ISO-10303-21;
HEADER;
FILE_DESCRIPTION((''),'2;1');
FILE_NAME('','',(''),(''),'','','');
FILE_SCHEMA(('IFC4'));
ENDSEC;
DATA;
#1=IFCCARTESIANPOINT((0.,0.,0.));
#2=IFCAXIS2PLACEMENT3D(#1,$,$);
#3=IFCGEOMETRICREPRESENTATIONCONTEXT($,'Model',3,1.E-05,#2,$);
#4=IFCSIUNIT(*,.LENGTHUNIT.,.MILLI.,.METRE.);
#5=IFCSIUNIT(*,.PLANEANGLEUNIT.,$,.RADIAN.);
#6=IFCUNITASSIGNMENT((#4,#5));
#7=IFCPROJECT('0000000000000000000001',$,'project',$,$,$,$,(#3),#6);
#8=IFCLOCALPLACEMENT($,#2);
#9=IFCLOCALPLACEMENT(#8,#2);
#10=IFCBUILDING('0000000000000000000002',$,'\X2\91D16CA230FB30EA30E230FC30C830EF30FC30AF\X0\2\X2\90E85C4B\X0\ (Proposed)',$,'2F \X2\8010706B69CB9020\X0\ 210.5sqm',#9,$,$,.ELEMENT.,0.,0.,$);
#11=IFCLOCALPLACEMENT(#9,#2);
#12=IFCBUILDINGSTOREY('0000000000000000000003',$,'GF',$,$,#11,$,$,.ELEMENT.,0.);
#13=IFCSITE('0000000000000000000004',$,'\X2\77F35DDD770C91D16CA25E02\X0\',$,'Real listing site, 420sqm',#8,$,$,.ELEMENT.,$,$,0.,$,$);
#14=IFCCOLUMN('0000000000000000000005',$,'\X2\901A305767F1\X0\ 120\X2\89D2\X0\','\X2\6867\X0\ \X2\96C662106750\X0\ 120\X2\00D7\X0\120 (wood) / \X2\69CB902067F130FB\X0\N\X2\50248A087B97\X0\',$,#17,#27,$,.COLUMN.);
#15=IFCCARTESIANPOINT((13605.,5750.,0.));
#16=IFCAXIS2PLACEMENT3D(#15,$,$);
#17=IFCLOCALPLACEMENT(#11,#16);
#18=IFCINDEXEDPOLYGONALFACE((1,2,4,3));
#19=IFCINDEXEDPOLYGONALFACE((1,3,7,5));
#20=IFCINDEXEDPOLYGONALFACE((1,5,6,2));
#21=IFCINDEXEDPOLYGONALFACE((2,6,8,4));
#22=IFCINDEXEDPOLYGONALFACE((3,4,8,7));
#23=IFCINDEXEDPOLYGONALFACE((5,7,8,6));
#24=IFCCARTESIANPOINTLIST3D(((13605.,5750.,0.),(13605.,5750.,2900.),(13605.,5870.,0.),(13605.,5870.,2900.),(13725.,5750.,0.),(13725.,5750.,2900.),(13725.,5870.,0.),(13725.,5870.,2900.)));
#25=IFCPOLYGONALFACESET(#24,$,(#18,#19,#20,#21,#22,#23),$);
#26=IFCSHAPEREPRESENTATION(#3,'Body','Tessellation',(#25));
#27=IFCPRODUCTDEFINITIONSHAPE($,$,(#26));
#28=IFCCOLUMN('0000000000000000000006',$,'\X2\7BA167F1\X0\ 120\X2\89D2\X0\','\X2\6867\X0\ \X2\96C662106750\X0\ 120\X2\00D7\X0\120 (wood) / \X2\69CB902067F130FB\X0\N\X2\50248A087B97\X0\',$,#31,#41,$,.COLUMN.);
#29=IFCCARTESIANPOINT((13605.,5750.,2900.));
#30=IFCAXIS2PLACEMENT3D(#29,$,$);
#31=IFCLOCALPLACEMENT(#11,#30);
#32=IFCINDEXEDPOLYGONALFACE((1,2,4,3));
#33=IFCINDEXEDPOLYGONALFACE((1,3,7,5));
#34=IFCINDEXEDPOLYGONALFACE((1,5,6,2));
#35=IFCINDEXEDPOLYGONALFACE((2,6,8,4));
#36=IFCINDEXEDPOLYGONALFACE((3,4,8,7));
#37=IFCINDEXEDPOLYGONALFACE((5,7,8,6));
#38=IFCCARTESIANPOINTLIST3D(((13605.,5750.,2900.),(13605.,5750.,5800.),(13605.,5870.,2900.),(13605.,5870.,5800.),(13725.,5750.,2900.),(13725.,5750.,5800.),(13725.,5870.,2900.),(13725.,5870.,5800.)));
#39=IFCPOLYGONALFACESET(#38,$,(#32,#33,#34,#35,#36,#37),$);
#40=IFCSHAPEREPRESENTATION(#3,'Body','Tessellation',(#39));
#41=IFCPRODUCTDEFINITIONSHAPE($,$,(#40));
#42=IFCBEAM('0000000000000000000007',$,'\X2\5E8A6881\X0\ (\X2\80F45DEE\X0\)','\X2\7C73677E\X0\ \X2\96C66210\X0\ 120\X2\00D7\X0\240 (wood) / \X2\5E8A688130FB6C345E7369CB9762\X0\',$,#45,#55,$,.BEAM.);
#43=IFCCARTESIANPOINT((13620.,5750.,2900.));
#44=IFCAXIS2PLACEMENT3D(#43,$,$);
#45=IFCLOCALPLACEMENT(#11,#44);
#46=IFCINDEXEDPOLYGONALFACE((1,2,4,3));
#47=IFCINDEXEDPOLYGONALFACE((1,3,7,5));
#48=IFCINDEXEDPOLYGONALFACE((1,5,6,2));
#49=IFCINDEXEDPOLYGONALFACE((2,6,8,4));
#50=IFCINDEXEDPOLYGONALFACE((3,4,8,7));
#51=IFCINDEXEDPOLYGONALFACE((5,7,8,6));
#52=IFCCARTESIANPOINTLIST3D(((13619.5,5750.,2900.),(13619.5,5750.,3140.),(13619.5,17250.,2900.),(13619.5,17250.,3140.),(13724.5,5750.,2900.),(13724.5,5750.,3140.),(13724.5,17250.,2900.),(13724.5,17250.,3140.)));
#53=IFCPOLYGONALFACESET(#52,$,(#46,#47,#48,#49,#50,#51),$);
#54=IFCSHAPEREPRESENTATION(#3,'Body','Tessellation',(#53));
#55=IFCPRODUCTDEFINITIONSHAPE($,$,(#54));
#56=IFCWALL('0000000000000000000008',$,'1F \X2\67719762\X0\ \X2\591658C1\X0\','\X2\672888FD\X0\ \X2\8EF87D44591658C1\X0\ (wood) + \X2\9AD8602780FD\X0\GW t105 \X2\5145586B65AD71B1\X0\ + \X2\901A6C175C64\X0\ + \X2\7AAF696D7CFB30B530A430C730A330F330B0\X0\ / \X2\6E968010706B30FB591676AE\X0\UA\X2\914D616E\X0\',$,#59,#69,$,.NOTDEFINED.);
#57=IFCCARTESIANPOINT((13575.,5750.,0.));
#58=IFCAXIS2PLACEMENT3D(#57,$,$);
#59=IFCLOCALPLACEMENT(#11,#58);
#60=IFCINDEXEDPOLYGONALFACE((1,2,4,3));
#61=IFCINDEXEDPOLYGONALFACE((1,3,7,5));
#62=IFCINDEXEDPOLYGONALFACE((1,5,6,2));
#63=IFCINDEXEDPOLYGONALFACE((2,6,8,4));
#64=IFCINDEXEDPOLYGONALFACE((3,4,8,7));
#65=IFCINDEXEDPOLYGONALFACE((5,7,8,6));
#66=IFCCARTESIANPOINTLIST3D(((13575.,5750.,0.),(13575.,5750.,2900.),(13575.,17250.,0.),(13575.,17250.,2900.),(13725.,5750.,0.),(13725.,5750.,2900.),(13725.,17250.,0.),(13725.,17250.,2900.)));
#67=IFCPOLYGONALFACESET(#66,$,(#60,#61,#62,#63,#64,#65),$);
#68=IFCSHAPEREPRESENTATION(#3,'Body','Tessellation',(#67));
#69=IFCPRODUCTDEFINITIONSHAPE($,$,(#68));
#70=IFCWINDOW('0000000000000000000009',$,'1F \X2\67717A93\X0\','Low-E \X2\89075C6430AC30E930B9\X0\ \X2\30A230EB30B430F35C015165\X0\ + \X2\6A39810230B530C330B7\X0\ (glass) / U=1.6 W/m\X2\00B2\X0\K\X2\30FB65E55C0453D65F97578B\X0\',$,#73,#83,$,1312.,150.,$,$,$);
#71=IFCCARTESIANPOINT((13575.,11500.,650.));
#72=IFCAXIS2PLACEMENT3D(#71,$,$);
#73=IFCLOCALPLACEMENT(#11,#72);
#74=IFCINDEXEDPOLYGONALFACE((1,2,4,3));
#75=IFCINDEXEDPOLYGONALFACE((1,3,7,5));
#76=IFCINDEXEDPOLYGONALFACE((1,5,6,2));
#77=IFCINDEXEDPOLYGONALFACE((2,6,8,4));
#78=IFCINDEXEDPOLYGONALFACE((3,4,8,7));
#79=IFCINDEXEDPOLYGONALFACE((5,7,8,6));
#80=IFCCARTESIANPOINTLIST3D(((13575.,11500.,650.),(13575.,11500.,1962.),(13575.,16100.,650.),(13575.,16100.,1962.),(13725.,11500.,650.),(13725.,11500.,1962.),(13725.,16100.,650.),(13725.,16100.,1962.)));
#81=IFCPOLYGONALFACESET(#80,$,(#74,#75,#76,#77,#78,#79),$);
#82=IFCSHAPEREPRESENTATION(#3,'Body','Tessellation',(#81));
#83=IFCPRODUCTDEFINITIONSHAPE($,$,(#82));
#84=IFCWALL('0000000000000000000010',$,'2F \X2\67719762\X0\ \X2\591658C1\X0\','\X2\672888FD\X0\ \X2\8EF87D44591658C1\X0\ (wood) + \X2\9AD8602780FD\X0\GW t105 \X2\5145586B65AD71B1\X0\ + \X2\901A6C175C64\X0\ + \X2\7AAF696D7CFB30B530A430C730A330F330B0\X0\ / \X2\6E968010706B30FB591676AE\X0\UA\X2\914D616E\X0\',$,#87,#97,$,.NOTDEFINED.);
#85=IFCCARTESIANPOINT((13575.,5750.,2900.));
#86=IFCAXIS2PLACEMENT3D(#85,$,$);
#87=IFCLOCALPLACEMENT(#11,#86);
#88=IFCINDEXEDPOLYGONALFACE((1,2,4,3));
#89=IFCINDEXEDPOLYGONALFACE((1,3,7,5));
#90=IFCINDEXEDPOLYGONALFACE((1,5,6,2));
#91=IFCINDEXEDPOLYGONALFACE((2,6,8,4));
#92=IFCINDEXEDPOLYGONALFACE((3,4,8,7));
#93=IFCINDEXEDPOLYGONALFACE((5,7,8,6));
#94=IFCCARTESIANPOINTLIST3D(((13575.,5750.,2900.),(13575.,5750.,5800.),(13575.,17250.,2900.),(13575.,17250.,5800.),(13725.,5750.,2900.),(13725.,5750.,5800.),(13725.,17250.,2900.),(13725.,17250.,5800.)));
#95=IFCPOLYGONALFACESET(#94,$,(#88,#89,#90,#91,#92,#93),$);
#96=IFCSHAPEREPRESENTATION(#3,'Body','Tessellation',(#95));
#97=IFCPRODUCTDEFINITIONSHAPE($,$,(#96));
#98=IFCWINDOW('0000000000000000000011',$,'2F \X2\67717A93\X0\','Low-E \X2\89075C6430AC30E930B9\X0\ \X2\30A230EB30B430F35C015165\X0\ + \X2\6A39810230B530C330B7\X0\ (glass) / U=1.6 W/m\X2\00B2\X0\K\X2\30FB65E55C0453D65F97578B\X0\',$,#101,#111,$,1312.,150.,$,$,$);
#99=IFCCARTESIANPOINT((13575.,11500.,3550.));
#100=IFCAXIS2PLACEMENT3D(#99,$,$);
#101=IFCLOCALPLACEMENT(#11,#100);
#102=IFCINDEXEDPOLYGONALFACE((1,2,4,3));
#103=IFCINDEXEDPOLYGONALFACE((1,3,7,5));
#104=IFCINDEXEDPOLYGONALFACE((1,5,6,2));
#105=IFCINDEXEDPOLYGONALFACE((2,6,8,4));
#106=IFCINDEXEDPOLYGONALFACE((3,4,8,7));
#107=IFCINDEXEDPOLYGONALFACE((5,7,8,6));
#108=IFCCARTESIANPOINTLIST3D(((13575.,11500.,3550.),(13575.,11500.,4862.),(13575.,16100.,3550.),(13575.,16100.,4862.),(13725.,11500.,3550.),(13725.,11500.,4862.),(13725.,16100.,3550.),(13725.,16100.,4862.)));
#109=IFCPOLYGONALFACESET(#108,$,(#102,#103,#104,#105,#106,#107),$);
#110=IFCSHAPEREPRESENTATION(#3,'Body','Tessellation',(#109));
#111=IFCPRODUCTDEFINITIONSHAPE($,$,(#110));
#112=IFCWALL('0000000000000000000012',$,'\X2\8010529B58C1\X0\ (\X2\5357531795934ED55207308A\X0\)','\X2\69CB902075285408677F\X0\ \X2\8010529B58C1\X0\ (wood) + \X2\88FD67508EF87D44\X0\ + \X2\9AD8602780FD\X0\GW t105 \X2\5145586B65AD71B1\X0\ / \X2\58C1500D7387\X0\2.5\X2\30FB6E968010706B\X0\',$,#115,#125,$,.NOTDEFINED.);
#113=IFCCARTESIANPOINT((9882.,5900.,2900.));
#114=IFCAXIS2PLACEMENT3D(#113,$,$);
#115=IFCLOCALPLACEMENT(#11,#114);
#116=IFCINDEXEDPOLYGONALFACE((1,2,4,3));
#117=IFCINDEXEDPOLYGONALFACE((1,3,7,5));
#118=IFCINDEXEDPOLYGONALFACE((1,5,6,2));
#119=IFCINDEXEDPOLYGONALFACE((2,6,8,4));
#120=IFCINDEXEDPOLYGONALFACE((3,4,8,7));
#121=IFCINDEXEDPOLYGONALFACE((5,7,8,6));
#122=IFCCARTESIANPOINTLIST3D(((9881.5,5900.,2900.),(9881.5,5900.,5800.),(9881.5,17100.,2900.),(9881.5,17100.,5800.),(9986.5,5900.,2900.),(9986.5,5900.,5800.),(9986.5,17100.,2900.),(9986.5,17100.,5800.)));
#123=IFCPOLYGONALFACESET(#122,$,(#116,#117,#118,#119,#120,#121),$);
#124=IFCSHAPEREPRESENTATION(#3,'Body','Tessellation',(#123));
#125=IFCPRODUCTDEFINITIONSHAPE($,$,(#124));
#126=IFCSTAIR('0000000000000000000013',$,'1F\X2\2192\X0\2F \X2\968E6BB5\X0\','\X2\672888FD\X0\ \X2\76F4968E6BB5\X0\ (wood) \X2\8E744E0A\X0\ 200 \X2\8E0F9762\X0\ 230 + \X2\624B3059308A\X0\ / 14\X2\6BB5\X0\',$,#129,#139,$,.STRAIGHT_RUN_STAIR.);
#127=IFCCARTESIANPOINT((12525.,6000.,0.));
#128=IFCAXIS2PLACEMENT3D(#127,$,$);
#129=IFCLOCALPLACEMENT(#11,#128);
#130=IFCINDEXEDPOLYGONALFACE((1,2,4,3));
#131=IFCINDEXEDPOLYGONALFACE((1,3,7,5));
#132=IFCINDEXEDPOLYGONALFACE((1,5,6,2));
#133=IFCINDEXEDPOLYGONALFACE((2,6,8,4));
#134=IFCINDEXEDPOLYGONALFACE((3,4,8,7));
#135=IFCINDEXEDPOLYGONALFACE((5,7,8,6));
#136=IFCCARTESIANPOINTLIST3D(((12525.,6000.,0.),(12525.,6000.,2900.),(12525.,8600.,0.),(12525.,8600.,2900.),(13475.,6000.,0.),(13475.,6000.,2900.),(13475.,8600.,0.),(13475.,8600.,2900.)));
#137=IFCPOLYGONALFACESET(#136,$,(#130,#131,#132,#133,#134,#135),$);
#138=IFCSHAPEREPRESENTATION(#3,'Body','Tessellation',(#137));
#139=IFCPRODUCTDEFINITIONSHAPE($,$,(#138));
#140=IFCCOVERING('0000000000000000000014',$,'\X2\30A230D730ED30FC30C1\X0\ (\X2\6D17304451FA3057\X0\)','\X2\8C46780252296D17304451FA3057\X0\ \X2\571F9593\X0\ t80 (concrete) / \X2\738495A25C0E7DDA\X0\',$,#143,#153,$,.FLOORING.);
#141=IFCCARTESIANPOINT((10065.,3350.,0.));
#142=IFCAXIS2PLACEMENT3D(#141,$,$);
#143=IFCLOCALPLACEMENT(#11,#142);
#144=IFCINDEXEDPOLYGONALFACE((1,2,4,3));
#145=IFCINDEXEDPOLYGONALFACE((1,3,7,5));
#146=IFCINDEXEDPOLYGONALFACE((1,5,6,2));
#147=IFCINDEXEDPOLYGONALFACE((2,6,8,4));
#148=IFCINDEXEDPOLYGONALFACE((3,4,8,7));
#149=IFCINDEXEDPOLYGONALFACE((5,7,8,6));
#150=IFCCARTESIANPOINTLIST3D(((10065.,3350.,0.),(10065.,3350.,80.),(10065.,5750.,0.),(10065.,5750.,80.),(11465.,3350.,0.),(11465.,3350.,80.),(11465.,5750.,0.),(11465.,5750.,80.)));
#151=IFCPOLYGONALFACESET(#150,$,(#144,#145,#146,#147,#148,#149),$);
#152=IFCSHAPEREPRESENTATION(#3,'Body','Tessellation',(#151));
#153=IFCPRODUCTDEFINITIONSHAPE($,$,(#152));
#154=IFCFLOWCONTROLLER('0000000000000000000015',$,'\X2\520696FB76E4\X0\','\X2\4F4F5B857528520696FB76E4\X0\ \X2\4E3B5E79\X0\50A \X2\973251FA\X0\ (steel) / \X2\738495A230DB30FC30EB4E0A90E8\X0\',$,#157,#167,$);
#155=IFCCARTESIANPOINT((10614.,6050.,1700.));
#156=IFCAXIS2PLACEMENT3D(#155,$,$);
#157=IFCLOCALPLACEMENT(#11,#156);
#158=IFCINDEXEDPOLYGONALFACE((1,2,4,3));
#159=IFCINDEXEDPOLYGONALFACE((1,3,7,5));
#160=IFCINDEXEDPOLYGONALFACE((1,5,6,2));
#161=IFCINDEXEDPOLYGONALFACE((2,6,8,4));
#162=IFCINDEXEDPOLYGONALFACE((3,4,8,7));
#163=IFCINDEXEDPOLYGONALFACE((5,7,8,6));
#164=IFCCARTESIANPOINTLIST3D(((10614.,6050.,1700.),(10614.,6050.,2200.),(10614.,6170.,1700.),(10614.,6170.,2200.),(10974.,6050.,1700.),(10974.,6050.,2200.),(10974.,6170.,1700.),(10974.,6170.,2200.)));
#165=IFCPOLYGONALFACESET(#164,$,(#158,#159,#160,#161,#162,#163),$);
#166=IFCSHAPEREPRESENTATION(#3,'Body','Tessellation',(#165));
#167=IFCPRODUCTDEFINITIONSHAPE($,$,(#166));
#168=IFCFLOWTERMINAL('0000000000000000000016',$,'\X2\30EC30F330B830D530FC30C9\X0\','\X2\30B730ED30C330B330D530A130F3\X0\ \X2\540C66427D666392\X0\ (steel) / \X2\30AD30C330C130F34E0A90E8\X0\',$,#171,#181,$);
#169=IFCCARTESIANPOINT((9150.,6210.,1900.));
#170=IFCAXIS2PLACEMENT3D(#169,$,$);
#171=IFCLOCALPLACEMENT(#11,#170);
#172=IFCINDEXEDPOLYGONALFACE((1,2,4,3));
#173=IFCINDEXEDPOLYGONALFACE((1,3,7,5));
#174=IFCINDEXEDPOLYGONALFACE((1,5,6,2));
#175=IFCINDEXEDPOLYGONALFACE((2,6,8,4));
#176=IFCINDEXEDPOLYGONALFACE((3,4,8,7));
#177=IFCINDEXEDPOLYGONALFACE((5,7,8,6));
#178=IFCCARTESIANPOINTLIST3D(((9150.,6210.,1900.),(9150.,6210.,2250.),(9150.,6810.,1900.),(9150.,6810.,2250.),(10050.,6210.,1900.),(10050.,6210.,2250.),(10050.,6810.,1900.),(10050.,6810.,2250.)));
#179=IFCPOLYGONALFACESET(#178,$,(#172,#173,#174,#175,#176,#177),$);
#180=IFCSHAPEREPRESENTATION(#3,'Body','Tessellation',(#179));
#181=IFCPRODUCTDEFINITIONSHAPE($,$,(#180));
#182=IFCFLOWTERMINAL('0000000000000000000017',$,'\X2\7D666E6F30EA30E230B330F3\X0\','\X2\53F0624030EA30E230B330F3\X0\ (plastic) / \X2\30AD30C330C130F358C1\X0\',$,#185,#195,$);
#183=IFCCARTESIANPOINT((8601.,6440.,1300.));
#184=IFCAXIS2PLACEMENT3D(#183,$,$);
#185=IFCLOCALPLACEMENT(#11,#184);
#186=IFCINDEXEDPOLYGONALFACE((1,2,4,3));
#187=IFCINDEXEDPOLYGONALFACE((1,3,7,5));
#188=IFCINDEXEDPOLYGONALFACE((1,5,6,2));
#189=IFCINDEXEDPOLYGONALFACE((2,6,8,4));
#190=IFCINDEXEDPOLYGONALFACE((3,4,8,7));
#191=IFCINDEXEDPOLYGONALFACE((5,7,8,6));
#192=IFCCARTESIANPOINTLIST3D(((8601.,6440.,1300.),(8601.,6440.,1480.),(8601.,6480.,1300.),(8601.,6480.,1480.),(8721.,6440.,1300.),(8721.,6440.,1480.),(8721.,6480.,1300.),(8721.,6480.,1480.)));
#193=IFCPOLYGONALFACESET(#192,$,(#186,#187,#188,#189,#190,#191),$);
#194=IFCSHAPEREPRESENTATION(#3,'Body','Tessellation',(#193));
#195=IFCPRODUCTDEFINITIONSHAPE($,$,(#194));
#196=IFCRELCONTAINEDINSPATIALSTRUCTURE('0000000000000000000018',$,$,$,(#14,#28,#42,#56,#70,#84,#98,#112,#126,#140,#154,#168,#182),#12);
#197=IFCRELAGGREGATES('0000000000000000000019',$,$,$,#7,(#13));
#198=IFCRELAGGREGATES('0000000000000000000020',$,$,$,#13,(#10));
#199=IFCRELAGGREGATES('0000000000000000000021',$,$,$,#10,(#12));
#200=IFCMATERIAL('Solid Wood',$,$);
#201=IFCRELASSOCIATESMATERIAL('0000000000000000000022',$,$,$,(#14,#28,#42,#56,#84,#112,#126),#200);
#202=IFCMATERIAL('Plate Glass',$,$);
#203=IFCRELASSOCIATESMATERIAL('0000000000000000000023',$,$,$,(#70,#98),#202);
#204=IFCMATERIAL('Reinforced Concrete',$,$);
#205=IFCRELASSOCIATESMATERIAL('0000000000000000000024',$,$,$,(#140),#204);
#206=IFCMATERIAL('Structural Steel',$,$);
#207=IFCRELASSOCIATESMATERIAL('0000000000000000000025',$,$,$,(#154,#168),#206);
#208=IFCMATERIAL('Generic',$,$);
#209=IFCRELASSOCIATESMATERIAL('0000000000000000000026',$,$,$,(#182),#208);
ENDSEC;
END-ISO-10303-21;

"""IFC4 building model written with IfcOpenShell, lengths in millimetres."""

from ifc_helpers import new_model, si_unit, frame, frame_2d, origin, place, context, project, spatial, rectangle, extrude, material, element, fill, save


model = new_model("IFC4")

# Units and contexts
model_context = context("Model", 3, precision=1e-05, world=origin())
ifc_project = project(units=[si_unit("LENGTHUNIT", "METRE", prefix="MILLI"), si_unit("PLANEANGLEUNIT", "RADIAN")], contexts=[model_context])

# Site, building, storey
site_placement = place(None, origin())
site = spatial("IfcSite", under=ifc_project, at=site_placement, Name="石川県金沢市", ObjectType="Real listing site, 420sqm", CompositionType="ELEMENT", RefElevation=0.0)
building_placement = place(site_placement, origin())
building = spatial("IfcBuilding", under=site, at=building_placement, Name="金沢・リモートワーク2部屋 (Proposed)", ObjectType="2F 耐火構造 210.5sqm", CompositionType="ELEMENT", ElevationOfRefHeight=0.0, ElevationOfTerrain=0.0)
storey_placement = place(building_placement, origin())
storey = spatial("IfcBuildingStorey", under=building, at=storey_placement, Name="GF", CompositionType="ELEMENT", Elevation=0.0)

# Columns
ifc_material_1 = material(Name="Solid Wood")
column_1_placement = place(storey_placement, frame((13605.0, 5750.0, 0.0)))
element("IfcColumn", 1, at=column_1_placement, inside=storey, material=ifc_material_1, Name="通し柱 120角", Description="桧 集成材 120×120 (wood) / 構造柱・N値計算", PredefinedType="COLUMN", context=model_context, shape_type="SweptSolid", body=[
    extrude(rectangle(XDim=120.0, YDim=120.0, at=frame_2d((60.0, 60.0))), frame((13605.0, 5750.0, 0.0)), (0.0, 0.0, 1.0), 2900.0),
])
column_2_placement = place(storey_placement, frame((13605.0, 5750.0, 2900.0)))
element("IfcColumn", 2, at=column_2_placement, inside=storey, material=ifc_material_1, Name="管柱 120角", Description="桧 集成材 120×120 (wood) / 構造柱・N値計算", PredefinedType="COLUMN", context=model_context, shape_type="SweptSolid", body=[
    extrude(rectangle(XDim=120.0, YDim=120.0, at=frame_2d((60.0, 60.0))), frame((13605.0, 5750.0, 2900.0)), (0.0, 0.0, 1.0), 2900.0),
])

# Beam
beam_1_placement = place(storey_placement, frame((13620.0, 5750.0, 2900.0)))
element("IfcBeam", 3, at=beam_1_placement, inside=storey, material=ifc_material_1, Name="床梁 (胴差)", Description="米松 集成 120×240 (wood) / 床梁・水平構面", PredefinedType="BEAM", context=model_context, shape_type="SweptSolid", body=[
    extrude(rectangle(XDim=105.0, YDim=11500.0, at=frame_2d((52.0, 5750.0))), frame((13620.0, 5750.0, 2900.0)), (0.0, 0.0, 1.0), 240.0),
])

# Wall, opening, window
wall_1_placement = place(storey_placement, frame((13575.0, 5750.0, 0.0)))
wall_1 = element("IfcWall", 4, at=wall_1_placement, inside=storey, material=ifc_material_1, Name="1F 東面 外壁", Description="木製 軸組外壁 (wood) + 高性能GW t105 充填断熱 + 通気層 + 窯業系サイディング / 準耐火・外皮UA配慮", PredefinedType="NOTDEFINED", context=model_context, shape_type="SweptSolid", body=[
    extrude(rectangle(XDim=150.0, YDim=11500.0, at=frame_2d((75.0, 5750.0))), frame((13575.0, 5750.0, 0.0)), (0.0, 0.0, 1.0), 2900.0),
])
opening_1_placement = place(storey_placement, frame((13575.0, 11500.0, 650.0)))
opening_1 = element("IfcOpeningElement", 5, at=opening_1_placement, cuts=wall_1, PredefinedType="NOTDEFINED", context=model_context, shape_type="SweptSolid", body=[
    extrude(rectangle(XDim=150.0, YDim=4600.0, at=frame_2d((75.0, 2300.0))), frame((13575.0, 11500.0, 650.0)), (0.0, 0.0, 1.0), 1312.0),
])
ifc_material_2 = material(Name="Plate Glass")
window_1_placement = place(storey_placement, frame((13575.0, 11500.0, 650.0)))
window_1 = element("IfcWindow", 6, at=window_1_placement, inside=storey, material=ifc_material_2, Name="1F 東窓", Description="Low-E 複層ガラス アルゴン封入 + 樹脂サッシ (glass) / U=1.6 W/m²K・日射取得型", OverallHeight=1312.0, OverallWidth=150.0, context=model_context, shape_type="SweptSolid", body=[
    extrude(rectangle(XDim=150.0, YDim=4600.0, at=frame_2d((75.0, 2300.0))), frame((13575.0, 11500.0, 650.0)), (0.0, 0.0, 1.0), 1312.0),
])
fill(opening_1, window_1)

# Wall, opening, window
wall_2_placement = place(storey_placement, frame((13575.0, 5750.0, 2900.0)))
wall_2 = element("IfcWall", 7, at=wall_2_placement, inside=storey, material=ifc_material_1, Name="2F 東面 外壁", Description="木製 軸組外壁 (wood) + 高性能GW t105 充填断熱 + 通気層 + 窯業系サイディング / 準耐火・外皮UA配慮", PredefinedType="NOTDEFINED", context=model_context, shape_type="SweptSolid", body=[
    extrude(rectangle(XDim=150.0, YDim=11500.0, at=frame_2d((75.0, 5750.0))), frame((13575.0, 5750.0, 2900.0)), (0.0, 0.0, 1.0), 2900.0),
])
opening_2_placement = place(storey_placement, frame((13575.0, 11500.0, 3550.0)))
opening_2 = element("IfcOpeningElement", 8, at=opening_2_placement, cuts=wall_2, PredefinedType="NOTDEFINED", context=model_context, shape_type="SweptSolid", body=[
    extrude(rectangle(XDim=150.0, YDim=4600.0, at=frame_2d((75.0, 2300.0))), frame((13575.0, 11500.0, 3550.0)), (0.0, 0.0, 1.0), 1312.0),
])
window_2_placement = place(storey_placement, frame((13575.0, 11500.0, 3550.0)))
window_2 = element("IfcWindow", 9, at=window_2_placement, inside=storey, material=ifc_material_2, Name="2F 東窓", Description="Low-E 複層ガラス アルゴン封入 + 樹脂サッシ (glass) / U=1.6 W/m²K・日射取得型", OverallHeight=1312.0, OverallWidth=150.0, context=model_context, shape_type="SweptSolid", body=[
    extrude(rectangle(XDim=150.0, YDim=4600.0, at=frame_2d((75.0, 2300.0))), frame((13575.0, 11500.0, 3550.0)), (0.0, 0.0, 1.0), 1312.0),
])
fill(opening_2, window_2)

# Wall
wall_3_placement = place(storey_placement, frame((9882.0, 5900.0, 2900.0)))
element("IfcWall", 10, at=wall_3_placement, inside=storey, material=ifc_material_1, Name="耐力壁 (南北間仕切り)", Description="構造用合板 耐力壁 (wood) + 製材軸組 + 高性能GW t105 充填断熱 / 壁倍率2.5・準耐火", PredefinedType="NOTDEFINED", context=model_context, shape_type="SweptSolid", body=[
    extrude(rectangle(XDim=105.0, YDim=11200.0, at=frame_2d((52.0, 5600.0))), frame((9882.0, 5900.0, 2900.0)), (0.0, 0.0, 1.0), 2900.0),
])

# Stair
stair_placement = place(storey_placement, frame((12525.0, 6000.0, 0.0)))
element("IfcStair", 11, at=stair_placement, inside=storey, material=ifc_material_1, Name="1F→2F 階段", Description="木製 直階段 (wood) 蹴上 200 踏面 230 + 手すり / 14段", PredefinedType="STRAIGHT_RUN_STAIR", context=model_context, shape_type="SweptSolid", body=[
    extrude(rectangle(XDim=950.0, YDim=2600.0, at=frame_2d((475.0, 1300.0))), frame((12525.0, 6000.0, 0.0)), (0.0, 0.0, 1.0), 2900.0),
])

# Covering
ifc_material_3 = material(Name="Reinforced Concrete")
covering_placement = place(storey_placement, frame((10065.0, 3350.0, 0.0)))
element("IfcCovering", 12, at=covering_placement, inside=storey, material=ifc_material_3, Name="アプローチ (洗い出し)", Description="豆砂利洗い出し 土間 t80 (concrete) / 玄関導線", PredefinedType="FLOORING", context=model_context, shape_type="SweptSolid", body=[
    extrude(rectangle(XDim=1400.0, YDim=2400.0, at=frame_2d((700.0, 1200.0))), frame((10065.0, 3350.0, 0.0)), (0.0, 0.0, 1.0), 80.0),
])

# Flow controller
ifc_material_4 = material(Name="Structural Steel")
flow_controller_placement = place(storey_placement, frame((10614.0, 6050.0, 1700.0)))
element("IfcFlowController", 13, at=flow_controller_placement, inside=storey, material=ifc_material_4, Name="分電盤", Description="住宅用分電盤 主幹50A 露出 (steel) / 玄関ホール上部", context=model_context, shape_type="SweptSolid", body=[
    extrude(rectangle(XDim=360.0, YDim=120.0, at=frame_2d((180.0, 60.0))), frame((10614.0, 6050.0, 1700.0)), (0.0, 0.0, 1.0), 500.0),
])

# Flow terminals
flow_terminal_1_placement = place(storey_placement, frame((9150.0, 6210.0, 1900.0)))
element("IfcFlowTerminal", 14, at=flow_terminal_1_placement, inside=storey, material=ifc_material_4, Name="レンジフード", Description="シロッコファン 同時給排 (steel) / キッチン上部", context=model_context, shape_type="SweptSolid", body=[
    extrude(rectangle(XDim=900.0, YDim=600.0, at=frame_2d((450.0, 300.0))), frame((9150.0, 6210.0, 1900.0)), (0.0, 0.0, 1.0), 350.0),
])
ifc_material_5 = material(Name="Generic")
flow_terminal_2_placement = place(storey_placement, frame((8601.0, 6440.0, 1300.0)))
element("IfcFlowTerminal", 15, at=flow_terminal_2_placement, inside=storey, material=ifc_material_5, Name="給湯リモコン", Description="台所リモコン (plastic) / キッチン壁", context=model_context, shape_type="SweptSolid", body=[
    extrude(rectangle(XDim=120.0, YDim=40.0, at=frame_2d((60.0, 20.0))), frame((8601.0, 6440.0, 1300.0)), (0.0, 0.0, 1.0), 180.0),
])

save(model, "model.ifc")
